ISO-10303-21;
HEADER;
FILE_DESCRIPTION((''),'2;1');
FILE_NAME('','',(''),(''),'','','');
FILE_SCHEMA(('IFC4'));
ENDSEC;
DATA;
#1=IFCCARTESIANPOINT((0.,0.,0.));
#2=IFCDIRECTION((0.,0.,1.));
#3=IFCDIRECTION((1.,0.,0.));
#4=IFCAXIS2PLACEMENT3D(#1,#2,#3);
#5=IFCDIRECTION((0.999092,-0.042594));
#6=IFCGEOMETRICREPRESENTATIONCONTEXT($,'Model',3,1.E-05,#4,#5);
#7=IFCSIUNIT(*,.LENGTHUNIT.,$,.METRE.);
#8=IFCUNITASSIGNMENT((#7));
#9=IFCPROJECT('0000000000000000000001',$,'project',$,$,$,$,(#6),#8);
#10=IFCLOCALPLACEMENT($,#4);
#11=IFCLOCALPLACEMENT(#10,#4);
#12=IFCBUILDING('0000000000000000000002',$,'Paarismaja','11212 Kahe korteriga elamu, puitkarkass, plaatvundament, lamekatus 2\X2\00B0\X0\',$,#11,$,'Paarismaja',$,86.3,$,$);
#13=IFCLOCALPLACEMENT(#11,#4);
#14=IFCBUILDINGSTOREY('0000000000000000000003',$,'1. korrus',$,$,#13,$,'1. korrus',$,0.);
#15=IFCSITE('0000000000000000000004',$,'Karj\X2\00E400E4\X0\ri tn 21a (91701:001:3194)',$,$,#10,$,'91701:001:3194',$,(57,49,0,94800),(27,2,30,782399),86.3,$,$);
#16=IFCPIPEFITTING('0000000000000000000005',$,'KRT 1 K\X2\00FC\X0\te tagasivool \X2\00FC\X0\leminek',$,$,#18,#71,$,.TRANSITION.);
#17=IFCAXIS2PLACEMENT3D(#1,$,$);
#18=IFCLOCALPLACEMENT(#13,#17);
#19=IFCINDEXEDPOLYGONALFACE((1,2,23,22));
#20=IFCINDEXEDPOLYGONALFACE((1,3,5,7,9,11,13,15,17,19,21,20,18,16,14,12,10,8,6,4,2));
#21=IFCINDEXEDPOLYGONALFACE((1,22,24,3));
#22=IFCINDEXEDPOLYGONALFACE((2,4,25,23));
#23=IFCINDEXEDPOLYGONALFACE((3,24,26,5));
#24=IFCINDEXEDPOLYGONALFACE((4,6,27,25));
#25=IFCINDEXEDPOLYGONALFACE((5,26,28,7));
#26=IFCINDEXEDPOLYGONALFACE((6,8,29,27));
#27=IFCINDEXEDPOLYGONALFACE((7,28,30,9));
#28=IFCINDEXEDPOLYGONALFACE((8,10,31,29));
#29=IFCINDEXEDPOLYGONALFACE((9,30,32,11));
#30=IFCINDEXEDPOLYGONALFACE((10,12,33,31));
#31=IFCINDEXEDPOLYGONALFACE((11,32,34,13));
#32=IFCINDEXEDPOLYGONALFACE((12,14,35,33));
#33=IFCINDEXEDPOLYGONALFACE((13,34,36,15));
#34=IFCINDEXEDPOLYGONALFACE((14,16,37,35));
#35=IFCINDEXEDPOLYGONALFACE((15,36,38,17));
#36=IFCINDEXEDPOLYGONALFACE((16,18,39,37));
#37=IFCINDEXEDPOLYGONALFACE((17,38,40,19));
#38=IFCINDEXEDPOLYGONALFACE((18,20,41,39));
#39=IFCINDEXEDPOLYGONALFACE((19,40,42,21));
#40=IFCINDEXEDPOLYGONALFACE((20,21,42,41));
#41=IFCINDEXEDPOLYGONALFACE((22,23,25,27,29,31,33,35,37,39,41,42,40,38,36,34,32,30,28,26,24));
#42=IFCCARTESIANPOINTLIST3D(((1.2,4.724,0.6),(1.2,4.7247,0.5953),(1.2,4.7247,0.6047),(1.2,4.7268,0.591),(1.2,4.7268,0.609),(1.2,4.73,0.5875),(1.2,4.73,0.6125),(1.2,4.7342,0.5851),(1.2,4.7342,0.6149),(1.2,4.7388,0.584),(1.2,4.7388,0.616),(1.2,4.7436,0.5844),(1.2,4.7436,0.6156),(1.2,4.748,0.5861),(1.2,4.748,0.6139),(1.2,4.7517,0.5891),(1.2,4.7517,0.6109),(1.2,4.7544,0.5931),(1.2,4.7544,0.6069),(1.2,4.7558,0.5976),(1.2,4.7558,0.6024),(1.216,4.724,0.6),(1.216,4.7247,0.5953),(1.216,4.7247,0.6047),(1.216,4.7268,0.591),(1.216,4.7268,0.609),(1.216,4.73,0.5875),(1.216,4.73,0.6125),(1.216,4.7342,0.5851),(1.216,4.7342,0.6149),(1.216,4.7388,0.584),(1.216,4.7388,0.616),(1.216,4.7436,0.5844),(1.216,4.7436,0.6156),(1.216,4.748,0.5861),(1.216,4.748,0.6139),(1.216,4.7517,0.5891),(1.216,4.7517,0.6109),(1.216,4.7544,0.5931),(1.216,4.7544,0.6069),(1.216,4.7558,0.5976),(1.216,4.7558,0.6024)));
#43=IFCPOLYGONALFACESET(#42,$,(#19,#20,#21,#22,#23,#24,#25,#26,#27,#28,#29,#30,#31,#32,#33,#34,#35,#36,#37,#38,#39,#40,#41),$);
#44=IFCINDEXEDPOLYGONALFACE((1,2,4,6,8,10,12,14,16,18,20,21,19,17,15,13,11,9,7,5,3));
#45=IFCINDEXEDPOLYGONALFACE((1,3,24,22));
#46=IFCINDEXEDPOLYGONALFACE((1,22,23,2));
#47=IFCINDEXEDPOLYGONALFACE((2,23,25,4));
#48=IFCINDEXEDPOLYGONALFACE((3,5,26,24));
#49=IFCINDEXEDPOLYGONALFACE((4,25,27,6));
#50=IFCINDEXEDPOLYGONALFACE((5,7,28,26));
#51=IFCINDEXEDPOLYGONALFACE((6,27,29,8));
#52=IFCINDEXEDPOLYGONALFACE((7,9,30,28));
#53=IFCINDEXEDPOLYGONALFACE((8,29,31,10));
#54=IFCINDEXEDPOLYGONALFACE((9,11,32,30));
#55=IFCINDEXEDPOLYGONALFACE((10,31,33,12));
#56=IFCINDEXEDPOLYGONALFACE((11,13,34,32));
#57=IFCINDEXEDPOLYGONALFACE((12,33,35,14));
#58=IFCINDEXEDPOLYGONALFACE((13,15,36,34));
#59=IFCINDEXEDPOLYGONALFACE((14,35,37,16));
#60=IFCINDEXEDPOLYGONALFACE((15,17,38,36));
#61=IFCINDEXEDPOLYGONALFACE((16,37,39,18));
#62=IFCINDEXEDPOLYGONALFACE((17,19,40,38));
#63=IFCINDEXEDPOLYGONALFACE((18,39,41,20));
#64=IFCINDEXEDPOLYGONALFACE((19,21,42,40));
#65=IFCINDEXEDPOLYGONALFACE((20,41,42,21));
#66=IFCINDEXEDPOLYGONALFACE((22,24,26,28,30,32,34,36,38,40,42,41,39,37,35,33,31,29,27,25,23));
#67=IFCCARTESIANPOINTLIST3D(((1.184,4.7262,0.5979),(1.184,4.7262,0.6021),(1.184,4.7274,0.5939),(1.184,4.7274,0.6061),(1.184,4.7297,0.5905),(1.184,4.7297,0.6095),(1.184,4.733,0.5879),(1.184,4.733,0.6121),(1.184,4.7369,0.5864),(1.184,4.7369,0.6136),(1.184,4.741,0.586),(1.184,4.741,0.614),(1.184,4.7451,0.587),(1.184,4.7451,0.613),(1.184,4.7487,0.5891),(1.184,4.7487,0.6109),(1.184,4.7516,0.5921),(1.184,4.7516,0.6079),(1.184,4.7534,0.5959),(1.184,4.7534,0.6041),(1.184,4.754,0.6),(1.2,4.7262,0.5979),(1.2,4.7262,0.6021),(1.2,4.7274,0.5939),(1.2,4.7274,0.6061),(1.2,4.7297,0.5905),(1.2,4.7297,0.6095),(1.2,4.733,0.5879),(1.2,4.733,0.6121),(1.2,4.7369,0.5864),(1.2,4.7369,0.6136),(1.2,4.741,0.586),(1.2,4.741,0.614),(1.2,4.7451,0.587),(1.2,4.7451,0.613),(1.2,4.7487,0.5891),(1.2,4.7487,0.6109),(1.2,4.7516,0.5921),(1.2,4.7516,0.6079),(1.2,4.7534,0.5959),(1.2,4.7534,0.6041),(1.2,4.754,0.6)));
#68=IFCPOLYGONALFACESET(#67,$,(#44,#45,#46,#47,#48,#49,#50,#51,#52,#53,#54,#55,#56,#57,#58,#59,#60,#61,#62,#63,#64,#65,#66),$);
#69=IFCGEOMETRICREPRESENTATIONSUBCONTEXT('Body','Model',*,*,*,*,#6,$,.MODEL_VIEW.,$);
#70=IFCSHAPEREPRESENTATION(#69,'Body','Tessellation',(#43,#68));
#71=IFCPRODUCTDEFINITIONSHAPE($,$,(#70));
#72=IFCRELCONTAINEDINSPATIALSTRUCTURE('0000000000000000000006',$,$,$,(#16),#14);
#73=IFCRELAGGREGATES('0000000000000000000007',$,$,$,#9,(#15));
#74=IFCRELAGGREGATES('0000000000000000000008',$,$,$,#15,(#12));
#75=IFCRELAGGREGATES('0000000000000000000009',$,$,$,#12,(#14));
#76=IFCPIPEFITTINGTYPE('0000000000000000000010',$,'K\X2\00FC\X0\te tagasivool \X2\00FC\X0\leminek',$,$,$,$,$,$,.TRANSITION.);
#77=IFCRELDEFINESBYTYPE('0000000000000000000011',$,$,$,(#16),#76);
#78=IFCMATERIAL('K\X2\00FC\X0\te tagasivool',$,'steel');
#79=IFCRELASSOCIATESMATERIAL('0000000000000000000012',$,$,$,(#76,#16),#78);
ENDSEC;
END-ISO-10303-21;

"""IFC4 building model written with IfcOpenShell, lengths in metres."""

from ifc_helpers import new_model, si_unit, direction, frame, origin_with_axes, place, context, subcontext, project, spatial, circle, extrude, material, type_object, element, save


model = new_model("IFC4")

# Units and contexts
model_context = context("Model", 3, precision=1e-05, world=origin_with_axes(), true_north=direction((0.999092, -0.042594)))
body_context = subcontext(model_context, "Body", "Model", "MODEL_VIEW")
ifc_project = project(units=[si_unit("LENGTHUNIT", "METRE")], contexts=[model_context])

# Site, building, storey
site_placement = place(None, origin_with_axes())
site = spatial("IfcSite", under=ifc_project, at=site_placement, Name="Karjääri tn 21a (91701:001:3194)", LongName="91701:001:3194", RefLatitude=(57, 49, 0, 94800), RefLongitude=(27, 2, 30, 782399), RefElevation=86.3)
building_placement = place(site_placement, origin_with_axes())
building = spatial("IfcBuilding", under=site, at=building_placement, Name="Paarismaja", Description="11212 Kahe korteriga elamu, puitkarkass, plaatvundament, lamekatus 2°", LongName="Paarismaja", ElevationOfRefHeight=86.3)
storey_placement = place(building_placement, origin_with_axes())
storey = spatial("IfcBuildingStorey", under=building, at=storey_placement, Name="1. korrus", LongName="1. korrus", Elevation=0.0)

# Pipe fitting
ifc_material_1 = material(Name="Küte tagasivool", Category="steel")
pipe_fitting_type_1 = type_object("IfcPipeFittingType", Name="Küte tagasivool üleminek", PredefinedType="TRANSITION", material=ifc_material_1)
pipe_fitting_1_placement = place(storey_placement, frame((1.2, 4.74, 0.6), z_axis=(0.0, 0.0, 1.0), x_axis=(1.0, 0.0, 0.0)))
element("IfcPipeFitting", 1, at=pipe_fitting_1_placement, inside=storey, type_object=pipe_fitting_type_1, material=ifc_material_1, Name="KRT 1 Küte tagasivool üleminek", PredefinedType="TRANSITION", context=body_context, shape_type="SweptSolid", body=[
    extrude(circle(Radius=0.016), frame((0.0, 0.0, 0.0), z_axis=(1.0, 0.0, 0.0), x_axis=(0.0, -1.0, 0.0)), (0.0, 0.0, 1.0), 0.016),
    extrude(circle(Radius=0.014), frame((0.0, 0.0, 0.0), z_axis=(-1.0, 0.0, 0.0), x_axis=(0.0, 1.0, 0.0)), (0.0, 0.0, 1.0), 0.016),
])

save(model, "model.ifc")
